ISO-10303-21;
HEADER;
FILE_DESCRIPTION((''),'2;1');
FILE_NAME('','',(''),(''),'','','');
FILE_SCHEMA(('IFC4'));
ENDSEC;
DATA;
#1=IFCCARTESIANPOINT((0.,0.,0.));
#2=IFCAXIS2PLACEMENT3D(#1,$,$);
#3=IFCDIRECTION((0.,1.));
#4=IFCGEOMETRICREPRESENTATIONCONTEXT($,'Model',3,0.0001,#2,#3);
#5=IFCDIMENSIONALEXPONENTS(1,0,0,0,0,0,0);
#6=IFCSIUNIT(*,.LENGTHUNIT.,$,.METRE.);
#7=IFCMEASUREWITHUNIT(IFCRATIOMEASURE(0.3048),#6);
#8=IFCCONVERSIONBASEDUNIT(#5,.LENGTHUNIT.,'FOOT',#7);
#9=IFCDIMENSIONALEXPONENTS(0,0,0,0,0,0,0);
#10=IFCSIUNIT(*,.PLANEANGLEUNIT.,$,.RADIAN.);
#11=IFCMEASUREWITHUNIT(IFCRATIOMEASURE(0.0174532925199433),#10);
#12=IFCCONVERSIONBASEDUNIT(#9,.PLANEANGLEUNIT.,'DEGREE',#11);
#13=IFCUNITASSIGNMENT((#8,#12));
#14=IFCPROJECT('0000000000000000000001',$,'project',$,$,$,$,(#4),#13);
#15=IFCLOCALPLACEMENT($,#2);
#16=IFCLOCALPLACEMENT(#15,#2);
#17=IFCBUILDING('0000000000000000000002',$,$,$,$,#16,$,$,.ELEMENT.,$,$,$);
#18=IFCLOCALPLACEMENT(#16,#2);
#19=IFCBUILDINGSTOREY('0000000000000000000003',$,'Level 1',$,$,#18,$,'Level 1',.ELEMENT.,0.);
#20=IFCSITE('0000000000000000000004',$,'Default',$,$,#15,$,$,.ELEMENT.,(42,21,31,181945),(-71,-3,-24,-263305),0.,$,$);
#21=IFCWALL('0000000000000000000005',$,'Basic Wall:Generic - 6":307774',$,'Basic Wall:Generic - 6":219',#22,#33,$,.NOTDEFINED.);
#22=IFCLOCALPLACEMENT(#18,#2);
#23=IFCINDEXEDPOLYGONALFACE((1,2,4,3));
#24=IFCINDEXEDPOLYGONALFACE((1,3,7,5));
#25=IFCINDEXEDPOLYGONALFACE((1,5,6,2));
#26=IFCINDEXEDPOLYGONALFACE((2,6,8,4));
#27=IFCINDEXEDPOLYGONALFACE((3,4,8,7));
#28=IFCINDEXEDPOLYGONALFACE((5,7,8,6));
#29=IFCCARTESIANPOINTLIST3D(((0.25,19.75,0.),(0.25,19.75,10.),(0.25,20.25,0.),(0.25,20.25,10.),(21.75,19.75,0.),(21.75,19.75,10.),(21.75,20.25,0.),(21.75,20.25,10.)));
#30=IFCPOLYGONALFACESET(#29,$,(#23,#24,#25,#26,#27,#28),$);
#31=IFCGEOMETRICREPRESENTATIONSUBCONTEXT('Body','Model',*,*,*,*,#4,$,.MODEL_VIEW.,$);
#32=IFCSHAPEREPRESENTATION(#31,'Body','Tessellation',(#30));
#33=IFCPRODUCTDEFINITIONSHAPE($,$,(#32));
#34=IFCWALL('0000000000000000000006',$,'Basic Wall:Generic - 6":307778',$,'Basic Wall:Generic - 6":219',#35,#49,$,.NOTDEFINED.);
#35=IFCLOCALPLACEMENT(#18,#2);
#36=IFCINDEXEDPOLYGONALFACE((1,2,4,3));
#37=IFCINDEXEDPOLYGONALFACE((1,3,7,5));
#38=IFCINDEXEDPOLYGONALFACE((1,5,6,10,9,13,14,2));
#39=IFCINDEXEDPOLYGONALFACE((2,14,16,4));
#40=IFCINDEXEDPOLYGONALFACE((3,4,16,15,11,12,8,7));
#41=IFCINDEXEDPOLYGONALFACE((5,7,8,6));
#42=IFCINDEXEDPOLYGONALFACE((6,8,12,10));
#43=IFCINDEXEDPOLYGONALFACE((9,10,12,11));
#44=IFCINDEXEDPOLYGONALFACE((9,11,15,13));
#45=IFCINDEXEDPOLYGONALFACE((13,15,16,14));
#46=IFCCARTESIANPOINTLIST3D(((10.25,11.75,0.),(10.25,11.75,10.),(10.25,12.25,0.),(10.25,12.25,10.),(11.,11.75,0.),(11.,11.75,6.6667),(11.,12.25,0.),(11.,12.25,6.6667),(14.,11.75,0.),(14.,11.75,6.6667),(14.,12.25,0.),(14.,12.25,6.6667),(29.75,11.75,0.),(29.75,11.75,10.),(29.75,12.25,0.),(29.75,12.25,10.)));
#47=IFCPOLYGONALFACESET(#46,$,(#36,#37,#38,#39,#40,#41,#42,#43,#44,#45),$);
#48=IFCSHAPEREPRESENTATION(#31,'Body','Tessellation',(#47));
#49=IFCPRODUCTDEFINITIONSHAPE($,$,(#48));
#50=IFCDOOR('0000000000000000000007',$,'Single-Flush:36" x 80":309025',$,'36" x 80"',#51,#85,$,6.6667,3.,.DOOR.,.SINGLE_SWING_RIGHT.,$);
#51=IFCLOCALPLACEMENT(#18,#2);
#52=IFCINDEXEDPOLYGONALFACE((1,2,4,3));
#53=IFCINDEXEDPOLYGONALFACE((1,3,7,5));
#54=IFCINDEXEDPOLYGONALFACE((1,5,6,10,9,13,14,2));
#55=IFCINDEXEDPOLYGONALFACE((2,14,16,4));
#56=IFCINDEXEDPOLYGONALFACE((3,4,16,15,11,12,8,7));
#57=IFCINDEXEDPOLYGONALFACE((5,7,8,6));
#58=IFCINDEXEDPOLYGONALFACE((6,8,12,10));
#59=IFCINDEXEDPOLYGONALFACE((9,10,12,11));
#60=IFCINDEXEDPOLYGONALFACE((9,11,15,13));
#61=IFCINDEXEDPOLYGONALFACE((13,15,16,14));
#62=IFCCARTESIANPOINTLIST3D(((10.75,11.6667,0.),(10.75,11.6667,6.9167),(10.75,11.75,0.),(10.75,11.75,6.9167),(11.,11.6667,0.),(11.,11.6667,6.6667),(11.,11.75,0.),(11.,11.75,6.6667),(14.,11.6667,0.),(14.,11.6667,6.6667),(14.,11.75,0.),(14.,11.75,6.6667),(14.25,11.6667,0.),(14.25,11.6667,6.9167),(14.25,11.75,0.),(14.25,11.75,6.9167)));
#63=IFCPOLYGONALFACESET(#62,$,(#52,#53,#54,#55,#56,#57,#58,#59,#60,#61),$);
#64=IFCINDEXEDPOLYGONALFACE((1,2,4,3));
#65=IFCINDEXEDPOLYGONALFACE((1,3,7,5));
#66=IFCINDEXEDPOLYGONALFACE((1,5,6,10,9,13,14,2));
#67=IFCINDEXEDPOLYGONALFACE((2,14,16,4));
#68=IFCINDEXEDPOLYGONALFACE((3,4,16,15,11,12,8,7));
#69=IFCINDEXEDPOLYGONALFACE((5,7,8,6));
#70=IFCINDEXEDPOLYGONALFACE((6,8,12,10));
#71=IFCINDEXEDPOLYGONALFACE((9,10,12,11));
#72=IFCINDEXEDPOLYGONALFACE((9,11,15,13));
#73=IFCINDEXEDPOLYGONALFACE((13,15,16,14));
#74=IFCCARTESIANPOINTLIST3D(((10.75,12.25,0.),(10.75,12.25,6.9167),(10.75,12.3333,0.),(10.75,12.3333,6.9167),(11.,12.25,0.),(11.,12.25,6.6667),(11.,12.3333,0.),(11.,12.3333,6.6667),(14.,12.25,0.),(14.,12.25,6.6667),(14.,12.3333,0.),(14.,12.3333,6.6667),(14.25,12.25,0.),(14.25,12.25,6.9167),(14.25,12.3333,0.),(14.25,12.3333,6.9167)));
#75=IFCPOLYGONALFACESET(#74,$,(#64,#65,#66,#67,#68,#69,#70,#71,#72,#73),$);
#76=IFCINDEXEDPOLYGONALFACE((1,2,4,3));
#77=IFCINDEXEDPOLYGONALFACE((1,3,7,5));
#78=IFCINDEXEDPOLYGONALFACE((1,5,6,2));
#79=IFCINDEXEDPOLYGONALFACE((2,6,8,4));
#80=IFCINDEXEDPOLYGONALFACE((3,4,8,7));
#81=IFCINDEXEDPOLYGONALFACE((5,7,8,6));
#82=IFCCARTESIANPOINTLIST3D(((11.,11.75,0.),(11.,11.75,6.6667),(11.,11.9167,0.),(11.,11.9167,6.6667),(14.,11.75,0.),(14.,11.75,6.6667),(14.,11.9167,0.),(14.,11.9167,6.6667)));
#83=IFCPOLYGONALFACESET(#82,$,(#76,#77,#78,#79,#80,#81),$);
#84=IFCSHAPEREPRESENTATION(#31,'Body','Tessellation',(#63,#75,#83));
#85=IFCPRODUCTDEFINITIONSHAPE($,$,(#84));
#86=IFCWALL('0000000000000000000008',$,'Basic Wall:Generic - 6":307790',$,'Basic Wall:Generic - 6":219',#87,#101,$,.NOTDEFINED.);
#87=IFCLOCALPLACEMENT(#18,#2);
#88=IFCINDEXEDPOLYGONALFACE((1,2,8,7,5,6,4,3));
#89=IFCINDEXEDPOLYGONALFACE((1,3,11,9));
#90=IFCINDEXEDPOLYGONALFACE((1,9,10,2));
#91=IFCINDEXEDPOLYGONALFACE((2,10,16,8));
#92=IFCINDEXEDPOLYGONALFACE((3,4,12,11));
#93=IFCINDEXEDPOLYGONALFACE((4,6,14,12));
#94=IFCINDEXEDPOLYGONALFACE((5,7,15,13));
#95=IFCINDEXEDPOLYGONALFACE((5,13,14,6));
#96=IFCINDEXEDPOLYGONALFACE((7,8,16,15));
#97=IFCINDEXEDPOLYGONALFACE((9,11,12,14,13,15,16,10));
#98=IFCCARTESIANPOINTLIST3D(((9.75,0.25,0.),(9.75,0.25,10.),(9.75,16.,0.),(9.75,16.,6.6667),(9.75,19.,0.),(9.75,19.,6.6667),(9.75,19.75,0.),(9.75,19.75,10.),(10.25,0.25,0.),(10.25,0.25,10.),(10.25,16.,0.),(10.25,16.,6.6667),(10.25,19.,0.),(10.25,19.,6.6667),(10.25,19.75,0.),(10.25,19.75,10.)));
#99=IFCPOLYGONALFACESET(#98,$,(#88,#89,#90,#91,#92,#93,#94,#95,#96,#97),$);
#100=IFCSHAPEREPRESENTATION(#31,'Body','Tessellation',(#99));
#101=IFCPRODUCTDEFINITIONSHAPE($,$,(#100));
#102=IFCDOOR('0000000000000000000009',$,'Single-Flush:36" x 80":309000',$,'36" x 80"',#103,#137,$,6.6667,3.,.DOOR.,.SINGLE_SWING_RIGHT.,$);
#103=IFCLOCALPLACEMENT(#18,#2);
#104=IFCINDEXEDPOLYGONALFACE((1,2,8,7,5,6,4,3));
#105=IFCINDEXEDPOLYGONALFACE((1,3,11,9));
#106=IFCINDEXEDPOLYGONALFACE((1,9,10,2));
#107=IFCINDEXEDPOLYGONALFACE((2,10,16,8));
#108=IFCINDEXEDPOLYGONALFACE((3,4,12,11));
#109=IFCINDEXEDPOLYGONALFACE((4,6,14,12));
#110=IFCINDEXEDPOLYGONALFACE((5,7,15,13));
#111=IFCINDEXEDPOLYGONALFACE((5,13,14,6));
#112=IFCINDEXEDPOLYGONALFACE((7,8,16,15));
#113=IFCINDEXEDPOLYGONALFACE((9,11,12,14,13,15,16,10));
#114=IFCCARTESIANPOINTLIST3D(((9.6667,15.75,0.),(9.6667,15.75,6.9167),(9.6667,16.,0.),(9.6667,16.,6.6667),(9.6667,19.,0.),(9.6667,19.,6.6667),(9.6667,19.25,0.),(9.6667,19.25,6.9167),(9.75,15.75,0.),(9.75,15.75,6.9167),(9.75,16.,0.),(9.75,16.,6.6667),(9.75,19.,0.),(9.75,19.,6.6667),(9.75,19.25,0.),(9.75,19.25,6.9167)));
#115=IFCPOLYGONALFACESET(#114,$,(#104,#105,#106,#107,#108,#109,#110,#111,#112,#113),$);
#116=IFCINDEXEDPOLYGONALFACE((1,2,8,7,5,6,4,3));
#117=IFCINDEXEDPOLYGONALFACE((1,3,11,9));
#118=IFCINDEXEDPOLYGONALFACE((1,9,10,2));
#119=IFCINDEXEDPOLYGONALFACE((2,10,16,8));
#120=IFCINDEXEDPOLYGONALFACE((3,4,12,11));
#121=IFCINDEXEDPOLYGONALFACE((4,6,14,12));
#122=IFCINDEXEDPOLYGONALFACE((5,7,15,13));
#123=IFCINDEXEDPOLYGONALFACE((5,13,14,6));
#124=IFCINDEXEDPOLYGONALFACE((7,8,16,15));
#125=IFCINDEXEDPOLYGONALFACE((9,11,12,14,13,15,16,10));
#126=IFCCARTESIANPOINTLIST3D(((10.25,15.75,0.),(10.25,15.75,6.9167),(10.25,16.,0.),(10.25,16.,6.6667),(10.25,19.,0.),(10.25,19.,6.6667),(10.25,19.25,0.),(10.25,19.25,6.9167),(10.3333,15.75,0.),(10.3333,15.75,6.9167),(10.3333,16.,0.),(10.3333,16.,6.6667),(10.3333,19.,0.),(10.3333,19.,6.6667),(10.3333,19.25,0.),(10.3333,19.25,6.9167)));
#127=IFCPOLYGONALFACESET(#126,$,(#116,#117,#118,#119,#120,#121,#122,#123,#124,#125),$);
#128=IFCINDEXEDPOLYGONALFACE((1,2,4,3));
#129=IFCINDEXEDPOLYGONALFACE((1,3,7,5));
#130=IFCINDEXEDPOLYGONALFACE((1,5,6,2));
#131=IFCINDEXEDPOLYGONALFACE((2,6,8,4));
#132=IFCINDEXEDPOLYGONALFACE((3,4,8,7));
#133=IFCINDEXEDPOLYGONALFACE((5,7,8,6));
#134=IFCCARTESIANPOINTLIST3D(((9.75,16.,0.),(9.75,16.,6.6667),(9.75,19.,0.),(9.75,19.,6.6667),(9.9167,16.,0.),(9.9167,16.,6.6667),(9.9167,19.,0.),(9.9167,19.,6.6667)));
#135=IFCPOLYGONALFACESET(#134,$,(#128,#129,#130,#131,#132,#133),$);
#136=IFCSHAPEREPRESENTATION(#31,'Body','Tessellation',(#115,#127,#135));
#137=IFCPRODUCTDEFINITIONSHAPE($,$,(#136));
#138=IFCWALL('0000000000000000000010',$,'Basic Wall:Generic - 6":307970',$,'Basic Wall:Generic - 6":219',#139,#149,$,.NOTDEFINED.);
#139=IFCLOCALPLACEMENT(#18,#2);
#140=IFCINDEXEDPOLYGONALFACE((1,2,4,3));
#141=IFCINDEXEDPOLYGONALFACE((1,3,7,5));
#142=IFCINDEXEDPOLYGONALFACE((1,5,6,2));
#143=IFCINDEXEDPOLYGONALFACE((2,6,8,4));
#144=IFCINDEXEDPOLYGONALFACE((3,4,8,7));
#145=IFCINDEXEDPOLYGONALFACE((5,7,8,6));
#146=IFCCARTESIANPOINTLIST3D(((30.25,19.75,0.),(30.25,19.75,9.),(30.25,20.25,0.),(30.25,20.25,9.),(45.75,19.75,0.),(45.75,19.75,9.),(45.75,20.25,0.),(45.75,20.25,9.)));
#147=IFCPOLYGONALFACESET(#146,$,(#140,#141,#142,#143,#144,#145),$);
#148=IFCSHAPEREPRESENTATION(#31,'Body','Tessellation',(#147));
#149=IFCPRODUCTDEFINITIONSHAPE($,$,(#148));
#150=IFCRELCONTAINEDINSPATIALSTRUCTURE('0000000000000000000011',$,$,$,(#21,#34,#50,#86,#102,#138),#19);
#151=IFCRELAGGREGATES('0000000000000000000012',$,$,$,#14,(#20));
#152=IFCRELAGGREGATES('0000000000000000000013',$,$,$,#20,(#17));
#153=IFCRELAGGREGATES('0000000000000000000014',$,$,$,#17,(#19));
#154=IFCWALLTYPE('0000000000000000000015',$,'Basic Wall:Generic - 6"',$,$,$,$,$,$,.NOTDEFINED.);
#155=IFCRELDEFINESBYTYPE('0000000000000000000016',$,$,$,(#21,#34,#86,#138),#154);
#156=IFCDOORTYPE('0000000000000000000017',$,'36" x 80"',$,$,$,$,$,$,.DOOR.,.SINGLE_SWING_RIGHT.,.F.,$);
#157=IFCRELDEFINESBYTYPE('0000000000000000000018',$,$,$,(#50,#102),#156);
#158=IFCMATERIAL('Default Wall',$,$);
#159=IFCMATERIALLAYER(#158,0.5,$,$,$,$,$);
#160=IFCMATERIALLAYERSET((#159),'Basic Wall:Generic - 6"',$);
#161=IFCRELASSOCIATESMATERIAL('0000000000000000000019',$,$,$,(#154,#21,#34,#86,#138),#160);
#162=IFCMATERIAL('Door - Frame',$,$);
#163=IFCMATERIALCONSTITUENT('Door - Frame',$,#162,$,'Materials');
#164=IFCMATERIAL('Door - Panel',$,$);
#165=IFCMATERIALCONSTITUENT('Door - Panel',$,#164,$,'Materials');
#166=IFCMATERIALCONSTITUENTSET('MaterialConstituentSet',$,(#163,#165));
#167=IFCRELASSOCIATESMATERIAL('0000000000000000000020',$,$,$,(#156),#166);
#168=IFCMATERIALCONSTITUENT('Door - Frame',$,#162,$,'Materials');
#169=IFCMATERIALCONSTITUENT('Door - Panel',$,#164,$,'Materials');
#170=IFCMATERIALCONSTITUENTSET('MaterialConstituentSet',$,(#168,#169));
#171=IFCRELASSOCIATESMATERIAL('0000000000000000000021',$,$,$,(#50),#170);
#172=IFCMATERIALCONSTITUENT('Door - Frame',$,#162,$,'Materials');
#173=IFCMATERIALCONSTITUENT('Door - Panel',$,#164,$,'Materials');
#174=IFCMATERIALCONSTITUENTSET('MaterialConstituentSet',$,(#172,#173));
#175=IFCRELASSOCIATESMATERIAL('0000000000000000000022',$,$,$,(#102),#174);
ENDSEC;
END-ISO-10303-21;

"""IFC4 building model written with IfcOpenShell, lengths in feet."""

from ifc_helpers import new_model, entity, si_unit, converted_unit, direction, frame, frame_2d, origin, origin_2d_with_axis, place, context, subcontext, project, spatial, polyline, rectangle, outline, extrude, source, transform, mapped, material, layer, layer_set, layer_usage, constituent, constituent_set, type_object, type_shapes, element, fill, save


model = new_model("IFC4")

# Units and contexts
model_context = context("Model", 3, precision=0.0001, world=origin(), true_north=direction((0.0, 1.0)))
body_context = subcontext(model_context, "Body", "Model", "MODEL_VIEW")
ifc_project = project(units=[converted_unit("LENGTHUNIT", "FOOT", entity("IfcRatioMeasure", 0.3048), si_unit("LENGTHUNIT", "METRE"), dimensions=[1, 0, 0, 0, 0, 0, 0]), converted_unit("PLANEANGLEUNIT", "DEGREE", entity("IfcRatioMeasure", 0.0174532925199433), si_unit("PLANEANGLEUNIT", "RADIAN"), dimensions=[0, 0, 0, 0, 0, 0, 0])], contexts=[model_context])

# Site, building, storey
site_placement = place(None, origin())
site = spatial("IfcSite", under=ifc_project, at=site_placement, Name="Default", CompositionType="ELEMENT", RefLatitude=(42, 21, 31, 181945), RefLongitude=(-71, -3, -24, -263305), RefElevation=0.0)
building_placement = place(site_placement, origin())
building = spatial("IfcBuilding", under=site, at=building_placement, CompositionType="ELEMENT")
storey_placement = place(building_placement, origin())
storey = spatial("IfcBuildingStorey", under=building, at=storey_placement, Name="Level 1", LongName="Level 1", CompositionType="ELEMENT", Elevation=0.0)

# Shared definitions
ifc_material_1 = material(Name="Default Wall")
ifc_layer = layer(ifc_material_1, 0.5)
ifc_layer_set = layer_set([ifc_layer], Name="Basic Wall:Generic - 6\"")
wall_type = type_object("IfcWallType", Name="Basic Wall:Generic - 6\"", PredefinedType="NOTDEFINED", material=ifc_layer_set)

# Wall
ifc_layer_usage_1 = layer_usage(ifc_layer_set, "AXIS2", "NEGATIVE", 0.25)
wall_1_placement = place(storey_placement, frame((0.25, 20.0, 0.0)))
element("IfcWall", 1, at=wall_1_placement, inside=storey, type_object=wall_type, material=ifc_layer_usage_1, Name="Basic Wall:Generic - 6\":307774", ObjectType="Basic Wall:Generic - 6\":219", PredefinedType="NOTDEFINED", context=body_context, shape_type="SweptSolid", body=[
    extrude(rectangle(XDim=21.5, YDim=0.5, at=frame_2d((10.75, 0.0), x_axis=(-1.0, 0.0))), origin(), (0.0, 0.0, 1.0), 10.0),
])

# Walls, openings, doors
ifc_layer_usage_2 = layer_usage(ifc_layer_set, "AXIS2", "NEGATIVE", 0.25)
wall_2_placement = place(storey_placement, frame((10.25, 12.0, 0.0)))
wall_2 = element("IfcWall", 2, at=wall_2_placement, inside=storey, type_object=wall_type, material=ifc_layer_usage_2, Name="Basic Wall:Generic - 6\":307778", ObjectType="Basic Wall:Generic - 6\":219", PredefinedType="NOTDEFINED", context=body_context, shape_type="SweptSolid", body=[
    extrude(rectangle(XDim=19.5, YDim=0.5, at=frame_2d((9.75, 0.0), x_axis=(-1.0, 0.0))), origin(), (0.0, 0.0, 1.0), 10.0),
])
opening_1_placement = place(wall_2_placement, frame((3.75, 0.25, 0.0)))
opening_1 = element("IfcOpeningElement", 3, at=opening_1_placement, cuts=wall_2, ObjectType="Opening", PredefinedType="OPENING", context=body_context, shape_type="SweptSolid", body=[
    extrude(rectangle(XDim=3.0, YDim=6.6667, at=frame_2d((3.3333, 1.5), x_axis=(0.0, 1.0))), frame((0.0, 0.0, 0.0), z_axis=(0.0, -1.0, 0.0), x_axis=(0.0, 0.0, 1.0)), (0.0, 0.0, 1.0), 0.5),
])
ifc_material_2 = material(Name="Door - Frame")
ifc_constituent_1 = constituent(ifc_material_2, Name="Door - Frame", Category="Materials")
ifc_material_3 = material(Name="Door - Panel")
ifc_constituent_2 = constituent(ifc_material_3, Name="Door - Panel", Category="Materials")
ifc_constituent_set_1 = constituent_set(constituents=[ifc_constituent_1, ifc_constituent_2], Name="MaterialConstituentSet")
ifc_constituent_3 = constituent(ifc_material_2, Name="Door - Frame", Category="Materials")
ifc_constituent_4 = constituent(ifc_material_3, Name="Door - Panel", Category="Materials")
ifc_constituent_set_2 = constituent_set(constituents=[ifc_constituent_3, ifc_constituent_4], Name="MaterialConstituentSet")
door_type = type_object("IfcDoorType", Name="36\" x 80\"", OperationType="SINGLE_SWING_RIGHT", ParameterTakesPrecedence=False, PredefinedType="DOOR", material=ifc_constituent_set_2)
shared_shape_1 = source(origin(), body_context, "Body", "SweptSolid", [
    extrude(outline(polyline([(-1.75, -3.5208), (1.75, -3.5208), (1.75, 3.3958), (1.5, 3.3958), (1.5, -3.2708), (-1.5, -3.2708), (-1.5, 3.3958), (-1.75, 3.3958), (-1.75, -3.5208)])), frame((1.5, 0.5, 3.3958), z_axis=(0.0, 1.0, 0.0), x_axis=(1.0, 0.0, 0.0)), (0.0, 0.0, 1.0), 0.0833),
    extrude(outline(polyline([(-3.5208, -1.75), (3.3958, -1.75), (3.3958, -1.5), (-3.2708, -1.5), (-3.2708, 1.5), (3.3958, 1.5), (3.3958, 1.75), (-3.5208, 1.75), (-3.5208, -1.75)])), frame((1.5, -0.0833, 3.3958), z_axis=(0.0, 1.0, 0.0), x_axis=(0.0, 0.0, -1.0)), (0.0, 0.0, 1.0), 0.0833),
    extrude(rectangle(XDim=0.1667, YDim=3.0, at=origin_2d_with_axis()), frame((1.5, 0.4167, 0.0), z_axis=(0.0, 0.0, 1.0), x_axis=(0.0, 1.0, 0.0)), (0.0, 0.0, 1.0), 6.6667),
])
type_shapes(door_type, [shared_shape_1])
door_1_placement = place(opening_1_placement, frame((0.0, 0.0, 0.0), z_axis=(0.0, 0.0, 1.0), x_axis=(-1.0, 0.0, 0.0)))
door_1 = element("IfcDoor", 4, at=door_1_placement, inside=storey, type_object=door_type, material=ifc_constituent_set_1, Name="Single-Flush:36\" x 80\":309025", ObjectType="36\" x 80\"", OperationType="SINGLE_SWING_RIGHT", OverallHeight=6.6667, OverallWidth=3.0, PredefinedType="DOOR", context=body_context, shape_type="MappedRepresentation", body=[
    mapped(shared_shape_1, transform((0.0, 0.0, 0.0), scale=1.0)),
])
fill(opening_1, door_1)
ifc_layer_usage_3 = layer_usage(ifc_layer_set, "AXIS2", "NEGATIVE", 0.25)
wall_3_placement = place(storey_placement, frame((10.0, 19.75, 0.0), z_axis=(0.0, 0.0, 1.0), x_axis=(0.0, -1.0, 0.0)))
wall_3 = element("IfcWall", 5, at=wall_3_placement, inside=storey, type_object=wall_type, material=ifc_layer_usage_3, Name="Basic Wall:Generic - 6\":307790", ObjectType="Basic Wall:Generic - 6\":219", PredefinedType="NOTDEFINED", context=body_context, shape_type="SweptSolid", body=[
    extrude(rectangle(XDim=19.5, YDim=0.5, at=frame_2d((9.75, 0.0), x_axis=(-1.0, 0.0))), origin(), (0.0, 0.0, 1.0), 10.0),
])
opening_2_placement = place(wall_3_placement, frame((3.75, 0.25, 0.0)))
opening_2 = element("IfcOpeningElement", 6, at=opening_2_placement, cuts=wall_3, ObjectType="Opening", PredefinedType="OPENING", context=body_context, shape_type="SweptSolid", body=[
    extrude(rectangle(XDim=3.0, YDim=6.6667, at=frame_2d((3.3333, 1.5), x_axis=(0.0, 1.0))), frame((0.0, 0.0, 0.0), z_axis=(0.0, -1.0, 0.0), x_axis=(0.0, 0.0, 1.0)), (0.0, 0.0, 1.0), 0.5),
])
ifc_constituent_5 = constituent(ifc_material_2, Name="Door - Frame", Category="Materials")
ifc_constituent_6 = constituent(ifc_material_3, Name="Door - Panel", Category="Materials")
ifc_constituent_set_3 = constituent_set(constituents=[ifc_constituent_5, ifc_constituent_6], Name="MaterialConstituentSet")
door_2_placement = place(opening_2_placement, frame((0.0, 0.0, 0.0), z_axis=(0.0, 0.0, 1.0), x_axis=(-1.0, 0.0, 0.0)))
door_2 = element("IfcDoor", 7, at=door_2_placement, inside=storey, type_object=door_type, material=ifc_constituent_set_3, Name="Single-Flush:36\" x 80\":309000", ObjectType="36\" x 80\"", OperationType="SINGLE_SWING_RIGHT", OverallHeight=6.6667, OverallWidth=3.0, PredefinedType="DOOR", context=body_context, shape_type="MappedRepresentation", body=[
    mapped(shared_shape_1, transform((0.0, 0.0, 0.0), scale=1.0)),
])
fill(opening_2, door_2)

# Wall
ifc_layer_usage_4 = layer_usage(ifc_layer_set, "AXIS2", "NEGATIVE", 0.25)
wall_4_placement = place(storey_placement, frame((30.25, 20.0, 0.0)))
element("IfcWall", 8, at=wall_4_placement, inside=storey, type_object=wall_type, material=ifc_layer_usage_4, Name="Basic Wall:Generic - 6\":307970", ObjectType="Basic Wall:Generic - 6\":219", PredefinedType="NOTDEFINED", context=body_context, shape_type="SweptSolid", body=[
    extrude(rectangle(XDim=15.5, YDim=0.5, at=frame_2d((7.75, 0.0), x_axis=(-1.0, 0.0))), origin(), (0.0, 0.0, 1.0), 9.0),
])

save(model, "model.ifc")
